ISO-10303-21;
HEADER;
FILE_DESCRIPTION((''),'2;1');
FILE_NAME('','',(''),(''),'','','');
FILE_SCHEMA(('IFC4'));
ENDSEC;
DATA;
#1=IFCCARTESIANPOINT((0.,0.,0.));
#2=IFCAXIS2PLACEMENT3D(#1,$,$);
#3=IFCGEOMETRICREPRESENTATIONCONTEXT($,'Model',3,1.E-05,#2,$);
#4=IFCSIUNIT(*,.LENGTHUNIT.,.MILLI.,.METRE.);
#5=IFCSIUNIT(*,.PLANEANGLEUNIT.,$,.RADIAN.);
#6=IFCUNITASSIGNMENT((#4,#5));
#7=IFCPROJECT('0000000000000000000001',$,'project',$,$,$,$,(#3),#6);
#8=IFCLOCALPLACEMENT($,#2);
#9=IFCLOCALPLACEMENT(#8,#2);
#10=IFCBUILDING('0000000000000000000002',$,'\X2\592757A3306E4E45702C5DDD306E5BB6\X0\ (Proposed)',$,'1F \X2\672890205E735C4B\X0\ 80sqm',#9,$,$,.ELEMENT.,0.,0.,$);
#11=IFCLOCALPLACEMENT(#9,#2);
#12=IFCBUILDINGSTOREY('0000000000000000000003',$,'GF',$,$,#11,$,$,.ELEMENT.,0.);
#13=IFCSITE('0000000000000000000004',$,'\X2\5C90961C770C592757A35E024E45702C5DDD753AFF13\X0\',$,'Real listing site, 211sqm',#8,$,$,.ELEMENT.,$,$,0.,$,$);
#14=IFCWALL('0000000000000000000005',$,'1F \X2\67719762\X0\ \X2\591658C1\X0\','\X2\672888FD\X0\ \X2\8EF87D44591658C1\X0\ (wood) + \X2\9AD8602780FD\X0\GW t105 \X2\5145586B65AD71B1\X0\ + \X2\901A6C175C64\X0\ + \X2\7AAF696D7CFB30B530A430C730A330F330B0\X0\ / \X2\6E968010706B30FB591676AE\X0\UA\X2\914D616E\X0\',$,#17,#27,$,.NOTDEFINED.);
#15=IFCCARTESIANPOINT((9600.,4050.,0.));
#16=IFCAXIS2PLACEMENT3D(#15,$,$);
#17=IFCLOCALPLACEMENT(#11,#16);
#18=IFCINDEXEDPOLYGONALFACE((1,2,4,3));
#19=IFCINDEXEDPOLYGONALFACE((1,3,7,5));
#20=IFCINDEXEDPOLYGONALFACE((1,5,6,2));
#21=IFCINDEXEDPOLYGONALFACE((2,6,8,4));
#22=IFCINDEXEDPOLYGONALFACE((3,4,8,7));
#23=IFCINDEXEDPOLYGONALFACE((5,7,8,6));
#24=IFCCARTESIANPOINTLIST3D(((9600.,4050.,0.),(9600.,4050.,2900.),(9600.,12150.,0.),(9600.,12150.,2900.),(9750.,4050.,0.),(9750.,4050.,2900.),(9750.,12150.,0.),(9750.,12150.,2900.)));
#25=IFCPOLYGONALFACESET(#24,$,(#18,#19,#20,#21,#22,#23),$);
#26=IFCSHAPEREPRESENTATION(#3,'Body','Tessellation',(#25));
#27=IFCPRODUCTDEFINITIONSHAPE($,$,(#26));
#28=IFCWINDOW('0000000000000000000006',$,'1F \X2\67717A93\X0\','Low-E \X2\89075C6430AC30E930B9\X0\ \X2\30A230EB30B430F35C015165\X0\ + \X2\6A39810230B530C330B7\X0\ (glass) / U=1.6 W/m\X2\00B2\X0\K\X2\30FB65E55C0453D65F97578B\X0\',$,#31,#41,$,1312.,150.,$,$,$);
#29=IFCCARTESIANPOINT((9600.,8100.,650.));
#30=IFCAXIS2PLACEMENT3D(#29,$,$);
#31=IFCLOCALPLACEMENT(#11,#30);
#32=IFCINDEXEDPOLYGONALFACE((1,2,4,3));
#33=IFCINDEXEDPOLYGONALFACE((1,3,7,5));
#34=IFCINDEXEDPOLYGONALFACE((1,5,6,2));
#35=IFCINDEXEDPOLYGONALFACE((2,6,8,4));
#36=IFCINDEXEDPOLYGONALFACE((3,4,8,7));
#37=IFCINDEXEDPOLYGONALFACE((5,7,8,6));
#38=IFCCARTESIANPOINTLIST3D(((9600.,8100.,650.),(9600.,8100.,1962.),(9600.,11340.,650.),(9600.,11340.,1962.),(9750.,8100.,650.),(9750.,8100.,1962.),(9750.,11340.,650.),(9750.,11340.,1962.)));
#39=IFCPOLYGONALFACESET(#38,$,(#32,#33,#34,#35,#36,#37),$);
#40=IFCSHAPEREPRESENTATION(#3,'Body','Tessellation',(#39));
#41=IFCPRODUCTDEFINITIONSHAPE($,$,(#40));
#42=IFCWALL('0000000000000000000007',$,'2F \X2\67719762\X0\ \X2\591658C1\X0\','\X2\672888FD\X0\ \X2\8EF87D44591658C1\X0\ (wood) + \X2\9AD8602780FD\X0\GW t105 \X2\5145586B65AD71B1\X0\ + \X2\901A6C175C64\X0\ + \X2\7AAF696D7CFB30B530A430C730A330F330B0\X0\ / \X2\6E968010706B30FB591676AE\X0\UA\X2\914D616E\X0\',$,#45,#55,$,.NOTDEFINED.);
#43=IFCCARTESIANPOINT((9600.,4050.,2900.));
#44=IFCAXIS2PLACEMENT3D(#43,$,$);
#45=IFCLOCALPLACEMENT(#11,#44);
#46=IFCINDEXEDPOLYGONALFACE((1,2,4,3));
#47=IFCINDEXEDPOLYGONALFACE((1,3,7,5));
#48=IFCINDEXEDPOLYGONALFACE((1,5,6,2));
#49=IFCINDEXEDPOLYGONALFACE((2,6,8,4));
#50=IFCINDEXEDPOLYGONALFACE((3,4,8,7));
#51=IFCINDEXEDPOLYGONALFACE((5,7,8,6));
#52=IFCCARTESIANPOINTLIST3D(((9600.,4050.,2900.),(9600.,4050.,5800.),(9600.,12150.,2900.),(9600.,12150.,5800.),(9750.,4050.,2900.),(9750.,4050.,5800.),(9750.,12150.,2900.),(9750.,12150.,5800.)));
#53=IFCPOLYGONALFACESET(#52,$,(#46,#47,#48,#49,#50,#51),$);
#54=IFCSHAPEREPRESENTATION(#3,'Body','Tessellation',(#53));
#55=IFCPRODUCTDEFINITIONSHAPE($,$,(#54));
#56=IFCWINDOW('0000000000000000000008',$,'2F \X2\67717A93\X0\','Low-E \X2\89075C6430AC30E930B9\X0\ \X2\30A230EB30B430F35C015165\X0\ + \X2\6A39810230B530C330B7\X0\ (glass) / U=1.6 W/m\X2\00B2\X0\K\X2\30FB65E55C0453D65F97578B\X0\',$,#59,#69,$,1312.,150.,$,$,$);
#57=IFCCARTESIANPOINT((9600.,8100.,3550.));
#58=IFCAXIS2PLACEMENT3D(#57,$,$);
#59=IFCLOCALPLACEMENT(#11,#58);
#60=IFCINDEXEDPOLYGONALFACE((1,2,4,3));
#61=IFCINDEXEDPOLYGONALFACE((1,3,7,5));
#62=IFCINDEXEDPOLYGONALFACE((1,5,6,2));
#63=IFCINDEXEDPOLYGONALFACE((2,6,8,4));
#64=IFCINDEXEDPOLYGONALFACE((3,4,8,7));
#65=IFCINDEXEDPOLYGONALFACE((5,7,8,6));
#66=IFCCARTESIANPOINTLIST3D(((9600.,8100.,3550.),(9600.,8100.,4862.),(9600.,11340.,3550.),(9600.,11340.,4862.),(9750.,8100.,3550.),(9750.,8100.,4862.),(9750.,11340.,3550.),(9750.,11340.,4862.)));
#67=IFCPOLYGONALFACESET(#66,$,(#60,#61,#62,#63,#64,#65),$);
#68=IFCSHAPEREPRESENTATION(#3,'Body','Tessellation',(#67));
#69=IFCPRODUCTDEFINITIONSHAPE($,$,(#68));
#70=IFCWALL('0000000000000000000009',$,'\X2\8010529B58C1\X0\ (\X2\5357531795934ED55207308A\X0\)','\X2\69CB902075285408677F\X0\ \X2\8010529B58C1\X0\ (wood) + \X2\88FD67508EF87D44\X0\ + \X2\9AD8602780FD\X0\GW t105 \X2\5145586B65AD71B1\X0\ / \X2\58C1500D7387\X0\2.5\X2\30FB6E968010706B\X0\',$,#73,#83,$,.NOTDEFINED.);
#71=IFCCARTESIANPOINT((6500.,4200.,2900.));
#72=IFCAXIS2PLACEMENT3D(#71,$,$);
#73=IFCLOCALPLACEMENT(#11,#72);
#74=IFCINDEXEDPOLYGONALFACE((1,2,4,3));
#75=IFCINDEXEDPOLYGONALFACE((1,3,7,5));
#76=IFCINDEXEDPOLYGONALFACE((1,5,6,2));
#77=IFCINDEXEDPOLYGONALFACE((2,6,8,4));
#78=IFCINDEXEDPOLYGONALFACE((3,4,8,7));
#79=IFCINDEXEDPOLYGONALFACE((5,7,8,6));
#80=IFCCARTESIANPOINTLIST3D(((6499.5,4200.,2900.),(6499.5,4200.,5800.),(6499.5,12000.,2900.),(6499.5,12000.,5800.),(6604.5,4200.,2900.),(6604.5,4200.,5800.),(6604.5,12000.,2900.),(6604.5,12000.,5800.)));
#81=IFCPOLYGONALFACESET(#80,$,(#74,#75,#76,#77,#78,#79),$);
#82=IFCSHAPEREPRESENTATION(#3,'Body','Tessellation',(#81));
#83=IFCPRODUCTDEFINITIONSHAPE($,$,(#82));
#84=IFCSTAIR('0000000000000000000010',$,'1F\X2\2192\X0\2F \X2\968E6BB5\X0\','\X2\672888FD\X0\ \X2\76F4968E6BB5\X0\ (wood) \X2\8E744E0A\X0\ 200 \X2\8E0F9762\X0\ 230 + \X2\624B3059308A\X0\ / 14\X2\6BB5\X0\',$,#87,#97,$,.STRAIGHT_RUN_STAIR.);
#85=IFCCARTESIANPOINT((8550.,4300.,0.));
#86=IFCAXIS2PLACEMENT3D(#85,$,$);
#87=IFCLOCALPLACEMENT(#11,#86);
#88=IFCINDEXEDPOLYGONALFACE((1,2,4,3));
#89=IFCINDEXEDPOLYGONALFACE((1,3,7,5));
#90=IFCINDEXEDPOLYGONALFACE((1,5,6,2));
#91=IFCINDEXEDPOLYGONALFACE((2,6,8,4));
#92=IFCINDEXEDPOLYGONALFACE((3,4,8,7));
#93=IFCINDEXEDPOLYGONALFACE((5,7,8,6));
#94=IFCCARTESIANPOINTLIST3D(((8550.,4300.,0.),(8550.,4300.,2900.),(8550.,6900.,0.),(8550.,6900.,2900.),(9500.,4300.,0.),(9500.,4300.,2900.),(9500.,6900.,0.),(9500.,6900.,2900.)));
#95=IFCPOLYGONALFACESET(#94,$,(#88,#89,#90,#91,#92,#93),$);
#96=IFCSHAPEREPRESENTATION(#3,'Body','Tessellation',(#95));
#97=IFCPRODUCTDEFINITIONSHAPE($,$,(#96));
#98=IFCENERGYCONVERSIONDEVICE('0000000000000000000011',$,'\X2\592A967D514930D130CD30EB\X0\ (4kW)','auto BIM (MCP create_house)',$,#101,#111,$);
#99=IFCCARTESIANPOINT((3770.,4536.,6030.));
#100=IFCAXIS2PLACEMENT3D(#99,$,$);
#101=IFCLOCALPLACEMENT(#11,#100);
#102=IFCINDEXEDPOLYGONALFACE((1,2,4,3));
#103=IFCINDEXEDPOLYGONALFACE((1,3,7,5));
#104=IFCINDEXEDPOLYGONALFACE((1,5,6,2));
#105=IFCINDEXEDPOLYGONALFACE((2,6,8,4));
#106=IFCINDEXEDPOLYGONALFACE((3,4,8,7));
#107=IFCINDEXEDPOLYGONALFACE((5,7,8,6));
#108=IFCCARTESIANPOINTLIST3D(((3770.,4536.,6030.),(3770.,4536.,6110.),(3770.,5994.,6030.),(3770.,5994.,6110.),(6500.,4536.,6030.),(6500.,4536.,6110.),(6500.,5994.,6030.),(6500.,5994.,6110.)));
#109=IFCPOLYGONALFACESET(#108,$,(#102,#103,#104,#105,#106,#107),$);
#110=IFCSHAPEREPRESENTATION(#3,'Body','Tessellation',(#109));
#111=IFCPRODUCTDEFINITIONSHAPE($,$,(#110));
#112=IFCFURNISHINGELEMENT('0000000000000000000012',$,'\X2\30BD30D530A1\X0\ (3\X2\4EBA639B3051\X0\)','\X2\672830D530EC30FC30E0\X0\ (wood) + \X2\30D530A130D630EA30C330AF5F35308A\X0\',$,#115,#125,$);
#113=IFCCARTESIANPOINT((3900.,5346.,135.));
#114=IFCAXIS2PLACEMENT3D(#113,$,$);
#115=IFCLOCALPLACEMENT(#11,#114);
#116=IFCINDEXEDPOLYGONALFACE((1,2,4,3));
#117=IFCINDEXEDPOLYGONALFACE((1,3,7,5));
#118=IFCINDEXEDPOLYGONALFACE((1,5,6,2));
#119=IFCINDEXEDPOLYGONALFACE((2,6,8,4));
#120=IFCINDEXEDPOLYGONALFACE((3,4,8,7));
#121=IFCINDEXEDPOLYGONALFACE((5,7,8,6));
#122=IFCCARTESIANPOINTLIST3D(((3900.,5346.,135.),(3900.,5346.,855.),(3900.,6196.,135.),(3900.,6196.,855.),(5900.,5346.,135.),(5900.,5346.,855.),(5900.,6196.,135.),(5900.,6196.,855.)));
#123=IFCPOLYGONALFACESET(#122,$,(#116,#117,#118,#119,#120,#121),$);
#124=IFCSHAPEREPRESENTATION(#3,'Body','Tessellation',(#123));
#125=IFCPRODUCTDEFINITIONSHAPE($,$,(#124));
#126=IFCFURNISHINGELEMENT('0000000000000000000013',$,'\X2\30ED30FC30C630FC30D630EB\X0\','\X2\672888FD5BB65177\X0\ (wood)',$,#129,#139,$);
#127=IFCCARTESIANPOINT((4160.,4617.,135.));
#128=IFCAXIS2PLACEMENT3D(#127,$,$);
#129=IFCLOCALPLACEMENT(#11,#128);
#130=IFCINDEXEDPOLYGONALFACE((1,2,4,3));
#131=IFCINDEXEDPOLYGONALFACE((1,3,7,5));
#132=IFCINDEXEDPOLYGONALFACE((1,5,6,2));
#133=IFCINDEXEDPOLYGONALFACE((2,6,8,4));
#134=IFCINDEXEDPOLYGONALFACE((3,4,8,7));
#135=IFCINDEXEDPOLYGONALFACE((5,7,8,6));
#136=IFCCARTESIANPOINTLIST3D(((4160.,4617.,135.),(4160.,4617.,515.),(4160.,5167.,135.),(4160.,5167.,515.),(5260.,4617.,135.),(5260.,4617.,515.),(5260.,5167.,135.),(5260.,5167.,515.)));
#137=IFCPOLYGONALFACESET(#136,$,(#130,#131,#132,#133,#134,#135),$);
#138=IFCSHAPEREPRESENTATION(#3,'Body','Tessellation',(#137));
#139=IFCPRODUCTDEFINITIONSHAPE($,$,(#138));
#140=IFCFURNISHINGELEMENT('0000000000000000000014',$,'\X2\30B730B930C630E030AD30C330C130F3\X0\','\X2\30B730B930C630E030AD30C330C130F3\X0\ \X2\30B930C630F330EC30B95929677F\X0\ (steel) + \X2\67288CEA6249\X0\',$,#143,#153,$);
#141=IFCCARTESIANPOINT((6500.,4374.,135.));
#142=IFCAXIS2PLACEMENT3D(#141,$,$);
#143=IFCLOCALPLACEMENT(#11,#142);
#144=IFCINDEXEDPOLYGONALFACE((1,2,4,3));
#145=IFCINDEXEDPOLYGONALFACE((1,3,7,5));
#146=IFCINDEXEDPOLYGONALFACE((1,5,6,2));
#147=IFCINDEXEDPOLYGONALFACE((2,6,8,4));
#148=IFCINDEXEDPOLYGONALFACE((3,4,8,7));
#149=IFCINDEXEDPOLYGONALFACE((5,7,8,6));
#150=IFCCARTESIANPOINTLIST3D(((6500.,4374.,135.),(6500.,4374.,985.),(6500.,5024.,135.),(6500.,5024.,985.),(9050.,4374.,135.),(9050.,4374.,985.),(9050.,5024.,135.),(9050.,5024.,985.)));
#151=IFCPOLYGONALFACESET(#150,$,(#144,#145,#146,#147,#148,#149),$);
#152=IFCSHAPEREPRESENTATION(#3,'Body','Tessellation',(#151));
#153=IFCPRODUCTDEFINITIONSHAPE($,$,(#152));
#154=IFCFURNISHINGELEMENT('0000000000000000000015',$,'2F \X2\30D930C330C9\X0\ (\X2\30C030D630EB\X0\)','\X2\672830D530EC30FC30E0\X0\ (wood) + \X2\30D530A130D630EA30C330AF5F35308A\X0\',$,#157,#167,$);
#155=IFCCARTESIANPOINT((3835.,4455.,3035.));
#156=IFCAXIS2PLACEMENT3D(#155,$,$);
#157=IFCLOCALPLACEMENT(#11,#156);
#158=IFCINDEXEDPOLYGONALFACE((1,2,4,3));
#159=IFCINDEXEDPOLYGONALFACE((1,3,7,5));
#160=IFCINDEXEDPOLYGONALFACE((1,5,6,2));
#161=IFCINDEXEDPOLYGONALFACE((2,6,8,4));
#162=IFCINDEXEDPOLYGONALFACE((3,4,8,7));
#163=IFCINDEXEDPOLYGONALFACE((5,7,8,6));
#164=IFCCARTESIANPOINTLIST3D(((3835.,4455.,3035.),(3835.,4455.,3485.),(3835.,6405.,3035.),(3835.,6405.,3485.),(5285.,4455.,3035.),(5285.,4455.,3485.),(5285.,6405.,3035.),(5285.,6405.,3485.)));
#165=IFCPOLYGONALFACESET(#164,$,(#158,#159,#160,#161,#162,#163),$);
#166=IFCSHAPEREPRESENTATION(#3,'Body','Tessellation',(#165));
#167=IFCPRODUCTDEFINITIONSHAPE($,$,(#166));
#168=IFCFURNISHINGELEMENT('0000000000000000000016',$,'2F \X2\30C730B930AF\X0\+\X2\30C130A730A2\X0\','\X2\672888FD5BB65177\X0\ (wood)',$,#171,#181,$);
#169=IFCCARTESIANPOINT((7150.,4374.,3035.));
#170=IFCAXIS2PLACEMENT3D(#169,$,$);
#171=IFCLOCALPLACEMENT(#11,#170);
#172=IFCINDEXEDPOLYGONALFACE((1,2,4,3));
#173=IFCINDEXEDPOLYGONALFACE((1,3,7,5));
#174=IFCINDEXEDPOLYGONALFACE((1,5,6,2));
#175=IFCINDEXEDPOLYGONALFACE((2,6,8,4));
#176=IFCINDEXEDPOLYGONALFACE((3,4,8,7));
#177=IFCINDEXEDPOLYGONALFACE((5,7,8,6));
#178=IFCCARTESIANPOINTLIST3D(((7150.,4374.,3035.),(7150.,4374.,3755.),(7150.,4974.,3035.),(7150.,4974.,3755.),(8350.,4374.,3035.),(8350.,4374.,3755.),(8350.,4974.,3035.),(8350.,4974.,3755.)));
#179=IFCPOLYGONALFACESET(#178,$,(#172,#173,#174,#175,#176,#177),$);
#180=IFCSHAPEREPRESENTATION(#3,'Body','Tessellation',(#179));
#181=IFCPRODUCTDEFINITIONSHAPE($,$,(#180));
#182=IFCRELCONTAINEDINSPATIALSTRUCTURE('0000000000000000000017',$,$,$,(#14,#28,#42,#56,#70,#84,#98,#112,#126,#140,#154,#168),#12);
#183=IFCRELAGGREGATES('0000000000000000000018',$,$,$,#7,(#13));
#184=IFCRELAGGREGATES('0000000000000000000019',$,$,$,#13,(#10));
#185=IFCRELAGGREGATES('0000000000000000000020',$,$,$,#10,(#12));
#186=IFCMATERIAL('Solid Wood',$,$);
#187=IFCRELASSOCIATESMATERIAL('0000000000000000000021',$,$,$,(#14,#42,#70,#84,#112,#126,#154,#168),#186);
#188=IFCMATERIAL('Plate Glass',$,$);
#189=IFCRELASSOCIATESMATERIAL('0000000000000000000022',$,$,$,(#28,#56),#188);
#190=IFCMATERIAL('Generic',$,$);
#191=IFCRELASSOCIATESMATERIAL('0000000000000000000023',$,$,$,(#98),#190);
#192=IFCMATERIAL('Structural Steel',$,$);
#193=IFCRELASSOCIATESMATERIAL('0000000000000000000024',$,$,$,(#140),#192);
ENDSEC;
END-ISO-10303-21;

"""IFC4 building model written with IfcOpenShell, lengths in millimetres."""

from ifc_helpers import new_model, si_unit, frame, frame_2d, origin, place, context, project, spatial, rectangle, extrude, material, element, fill, save


model = new_model("IFC4")

# Units and contexts
model_context = context("Model", 3, precision=1e-05, world=origin())
ifc_project = project(units=[si_unit("LENGTHUNIT", "METRE", prefix="MILLI"), si_unit("PLANEANGLEUNIT", "RADIAN")], contexts=[model_context])

# Site, building, storey
site_placement = place(None, origin())
site = spatial("IfcSite", under=ifc_project, at=site_placement, Name="岐阜県大垣市久瀬川町３", ObjectType="Real listing site, 211sqm", CompositionType="ELEMENT", RefElevation=0.0)
building_placement = place(site_placement, origin())
building = spatial("IfcBuilding", under=site, at=building_placement, Name="大垣の久瀬川の家 (Proposed)", ObjectType="1F 木造平屋 80sqm", CompositionType="ELEMENT", ElevationOfRefHeight=0.0, ElevationOfTerrain=0.0)
storey_placement = place(building_placement, origin())
storey = spatial("IfcBuildingStorey", under=building, at=storey_placement, Name="GF", CompositionType="ELEMENT", Elevation=0.0)

# Wall, opening, window
ifc_material_1 = material(Name="Solid Wood")
wall_1_placement = place(storey_placement, frame((9600.0, 4050.0, 0.0)))
wall_1 = element("IfcWall", 1, at=wall_1_placement, inside=storey, material=ifc_material_1, Name="1F 東面 外壁", Description="木製 軸組外壁 (wood) + 高性能GW t105 充填断熱 + 通気層 + 窯業系サイディング / 準耐火・外皮UA配慮", PredefinedType="NOTDEFINED", context=model_context, shape_type="SweptSolid", body=[
    extrude(rectangle(XDim=150.0, YDim=8100.0, at=frame_2d((75.0, 4050.0))), frame((9600.0, 4050.0, 0.0)), (0.0, 0.0, 1.0), 2900.0),
])
opening_1_placement = place(storey_placement, frame((9600.0, 8100.0, 650.0)))
opening_1 = element("IfcOpeningElement", 2, at=opening_1_placement, cuts=wall_1, PredefinedType="NOTDEFINED", context=model_context, shape_type="SweptSolid", body=[
    extrude(rectangle(XDim=150.0, YDim=3240.0, at=frame_2d((75.0, 1620.0))), frame((9600.0, 8100.0, 650.0)), (0.0, 0.0, 1.0), 1312.0),
])
ifc_material_2 = material(Name="Plate Glass")
window_1_placement = place(storey_placement, frame((9600.0, 8100.0, 650.0)))
window_1 = element("IfcWindow", 3, at=window_1_placement, inside=storey, material=ifc_material_2, Name="1F 東窓", Description="Low-E 複層ガラス アルゴン封入 + 樹脂サッシ (glass) / U=1.6 W/m²K・日射取得型", OverallHeight=1312.0, OverallWidth=150.0, context=model_context, shape_type="SweptSolid", body=[
    extrude(rectangle(XDim=150.0, YDim=3240.0, at=frame_2d((75.0, 1620.0))), frame((9600.0, 8100.0, 650.0)), (0.0, 0.0, 1.0), 1312.0),
])
fill(opening_1, window_1)

# Wall, opening, window
wall_2_placement = place(storey_placement, frame((9600.0, 4050.0, 2900.0)))
wall_2 = element("IfcWall", 4, at=wall_2_placement, inside=storey, material=ifc_material_1, Name="2F 東面 外壁", Description="木製 軸組外壁 (wood) + 高性能GW t105 充填断熱 + 通気層 + 窯業系サイディング / 準耐火・外皮UA配慮", PredefinedType="NOTDEFINED", context=model_context, shape_type="SweptSolid", body=[
    extrude(rectangle(XDim=150.0, YDim=8100.0, at=frame_2d((75.0, 4050.0))), frame((9600.0, 4050.0, 2900.0)), (0.0, 0.0, 1.0), 2900.0),
])
opening_2_placement = place(storey_placement, frame((9600.0, 8100.0, 3550.0)))
opening_2 = element("IfcOpeningElement", 5, at=opening_2_placement, cuts=wall_2, PredefinedType="NOTDEFINED", context=model_context, shape_type="SweptSolid", body=[
    extrude(rectangle(XDim=150.0, YDim=3240.0, at=frame_2d((75.0, 1620.0))), frame((9600.0, 8100.0, 3550.0)), (0.0, 0.0, 1.0), 1312.0),
])
window_2_placement = place(storey_placement, frame((9600.0, 8100.0, 3550.0)))
window_2 = element("IfcWindow", 6, at=window_2_placement, inside=storey, material=ifc_material_2, Name="2F 東窓", Description="Low-E 複層ガラス アルゴン封入 + 樹脂サッシ (glass) / U=1.6 W/m²K・日射取得型", OverallHeight=1312.0, OverallWidth=150.0, context=model_context, shape_type="SweptSolid", body=[
    extrude(rectangle(XDim=150.0, YDim=3240.0, at=frame_2d((75.0, 1620.0))), frame((9600.0, 8100.0, 3550.0)), (0.0, 0.0, 1.0), 1312.0),
])
fill(opening_2, window_2)

# Wall
wall_3_placement = place(storey_placement, frame((6500.0, 4200.0, 2900.0)))
element("IfcWall", 7, at=wall_3_placement, inside=storey, material=ifc_material_1, Name="耐力壁 (南北間仕切り)", Description="構造用合板 耐力壁 (wood) + 製材軸組 + 高性能GW t105 充填断熱 / 壁倍率2.5・準耐火", PredefinedType="NOTDEFINED", context=model_context, shape_type="SweptSolid", body=[
    extrude(rectangle(XDim=105.0, YDim=7800.0, at=frame_2d((52.0, 3900.0))), frame((6500.0, 4200.0, 2900.0)), (0.0, 0.0, 1.0), 2900.0),
])

# Stair
stair_placement = place(storey_placement, frame((8550.0, 4300.0, 0.0)))
element("IfcStair", 8, at=stair_placement, inside=storey, material=ifc_material_1, Name="1F→2F 階段", Description="木製 直階段 (wood) 蹴上 200 踏面 230 + 手すり / 14段", PredefinedType="STRAIGHT_RUN_STAIR", context=model_context, shape_type="SweptSolid", body=[
    extrude(rectangle(XDim=950.0, YDim=2600.0, at=frame_2d((475.0, 1300.0))), frame((8550.0, 4300.0, 0.0)), (0.0, 0.0, 1.0), 2900.0),
])

# Energy conversion device
ifc_material_3 = material(Name="Generic")
energy_conversion_device_placement = place(storey_placement, frame((3770.0, 4536.0, 6030.0)))
element("IfcEnergyConversionDevice", 9, at=energy_conversion_device_placement, inside=storey, material=ifc_material_3, Name="太陽光パネル (4kW)", Description="auto BIM (MCP create_house)", context=model_context, shape_type="SweptSolid", body=[
    extrude(rectangle(XDim=2730.0, YDim=1458.0, at=frame_2d((1365.0, 729.0))), frame((3770.0, 4536.0, 6030.0)), (0.0, 0.0, 1.0), 80.0),
])

# Furnishing elements
furnishing_1_placement = place(storey_placement, frame((3900.0, 5346.0, 135.0)))
element("IfcFurnishingElement", 10, at=furnishing_1_placement, inside=storey, material=ifc_material_1, Name="ソファ (3人掛け)", Description="木フレーム (wood) + ファブリック張り", context=model_context, shape_type="SweptSolid", body=[
    extrude(rectangle(XDim=2000.0, YDim=850.0, at=frame_2d((1000.0, 425.0))), frame((3900.0, 5346.0, 135.0)), (0.0, 0.0, 1.0), 720.0),
])
furnishing_2_placement = place(storey_placement, frame((4160.0, 4617.0, 135.0)))
element("IfcFurnishingElement", 11, at=furnishing_2_placement, inside=storey, material=ifc_material_1, Name="ローテーブル", Description="木製家具 (wood)", context=model_context, shape_type="SweptSolid", body=[
    extrude(rectangle(XDim=1100.0, YDim=550.0, at=frame_2d((550.0, 275.0))), frame((4160.0, 4617.0, 135.0)), (0.0, 0.0, 1.0), 380.0),
])
ifc_material_4 = material(Name="Structural Steel")
furnishing_3_placement = place(storey_placement, frame((6500.0, 4374.0, 135.0)))
element("IfcFurnishingElement", 12, at=furnishing_3_placement, inside=storey, material=ifc_material_4, Name="システムキッチン", Description="システムキッチン ステンレス天板 (steel) + 木質扉", context=model_context, shape_type="SweptSolid", body=[
    extrude(rectangle(XDim=2550.0, YDim=650.0, at=frame_2d((1275.0, 325.0))), frame((6500.0, 4374.0, 135.0)), (0.0, 0.0, 1.0), 850.0),
])
furnishing_4_placement = place(storey_placement, frame((3835.0, 4455.0, 3035.0)))
element("IfcFurnishingElement", 13, at=furnishing_4_placement, inside=storey, material=ifc_material_1, Name="2F ベッド (ダブル)", Description="木フレーム (wood) + ファブリック張り", context=model_context, shape_type="SweptSolid", body=[
    extrude(rectangle(XDim=1450.0, YDim=1950.0, at=frame_2d((725.0, 975.0))), frame((3835.0, 4455.0, 3035.0)), (0.0, 0.0, 1.0), 450.0),
])
furnishing_5_placement = place(storey_placement, frame((7150.0, 4374.0, 3035.0)))
element("IfcFurnishingElement", 14, at=furnishing_5_placement, inside=storey, material=ifc_material_1, Name="2F デスク+チェア", Description="木製家具 (wood)", context=model_context, shape_type="SweptSolid", body=[
    extrude(rectangle(XDim=1200.0, YDim=600.0, at=frame_2d((600.0, 300.0))), frame((7150.0, 4374.0, 3035.0)), (0.0, 0.0, 1.0), 720.0),
])

save(model, "model.ifc")
